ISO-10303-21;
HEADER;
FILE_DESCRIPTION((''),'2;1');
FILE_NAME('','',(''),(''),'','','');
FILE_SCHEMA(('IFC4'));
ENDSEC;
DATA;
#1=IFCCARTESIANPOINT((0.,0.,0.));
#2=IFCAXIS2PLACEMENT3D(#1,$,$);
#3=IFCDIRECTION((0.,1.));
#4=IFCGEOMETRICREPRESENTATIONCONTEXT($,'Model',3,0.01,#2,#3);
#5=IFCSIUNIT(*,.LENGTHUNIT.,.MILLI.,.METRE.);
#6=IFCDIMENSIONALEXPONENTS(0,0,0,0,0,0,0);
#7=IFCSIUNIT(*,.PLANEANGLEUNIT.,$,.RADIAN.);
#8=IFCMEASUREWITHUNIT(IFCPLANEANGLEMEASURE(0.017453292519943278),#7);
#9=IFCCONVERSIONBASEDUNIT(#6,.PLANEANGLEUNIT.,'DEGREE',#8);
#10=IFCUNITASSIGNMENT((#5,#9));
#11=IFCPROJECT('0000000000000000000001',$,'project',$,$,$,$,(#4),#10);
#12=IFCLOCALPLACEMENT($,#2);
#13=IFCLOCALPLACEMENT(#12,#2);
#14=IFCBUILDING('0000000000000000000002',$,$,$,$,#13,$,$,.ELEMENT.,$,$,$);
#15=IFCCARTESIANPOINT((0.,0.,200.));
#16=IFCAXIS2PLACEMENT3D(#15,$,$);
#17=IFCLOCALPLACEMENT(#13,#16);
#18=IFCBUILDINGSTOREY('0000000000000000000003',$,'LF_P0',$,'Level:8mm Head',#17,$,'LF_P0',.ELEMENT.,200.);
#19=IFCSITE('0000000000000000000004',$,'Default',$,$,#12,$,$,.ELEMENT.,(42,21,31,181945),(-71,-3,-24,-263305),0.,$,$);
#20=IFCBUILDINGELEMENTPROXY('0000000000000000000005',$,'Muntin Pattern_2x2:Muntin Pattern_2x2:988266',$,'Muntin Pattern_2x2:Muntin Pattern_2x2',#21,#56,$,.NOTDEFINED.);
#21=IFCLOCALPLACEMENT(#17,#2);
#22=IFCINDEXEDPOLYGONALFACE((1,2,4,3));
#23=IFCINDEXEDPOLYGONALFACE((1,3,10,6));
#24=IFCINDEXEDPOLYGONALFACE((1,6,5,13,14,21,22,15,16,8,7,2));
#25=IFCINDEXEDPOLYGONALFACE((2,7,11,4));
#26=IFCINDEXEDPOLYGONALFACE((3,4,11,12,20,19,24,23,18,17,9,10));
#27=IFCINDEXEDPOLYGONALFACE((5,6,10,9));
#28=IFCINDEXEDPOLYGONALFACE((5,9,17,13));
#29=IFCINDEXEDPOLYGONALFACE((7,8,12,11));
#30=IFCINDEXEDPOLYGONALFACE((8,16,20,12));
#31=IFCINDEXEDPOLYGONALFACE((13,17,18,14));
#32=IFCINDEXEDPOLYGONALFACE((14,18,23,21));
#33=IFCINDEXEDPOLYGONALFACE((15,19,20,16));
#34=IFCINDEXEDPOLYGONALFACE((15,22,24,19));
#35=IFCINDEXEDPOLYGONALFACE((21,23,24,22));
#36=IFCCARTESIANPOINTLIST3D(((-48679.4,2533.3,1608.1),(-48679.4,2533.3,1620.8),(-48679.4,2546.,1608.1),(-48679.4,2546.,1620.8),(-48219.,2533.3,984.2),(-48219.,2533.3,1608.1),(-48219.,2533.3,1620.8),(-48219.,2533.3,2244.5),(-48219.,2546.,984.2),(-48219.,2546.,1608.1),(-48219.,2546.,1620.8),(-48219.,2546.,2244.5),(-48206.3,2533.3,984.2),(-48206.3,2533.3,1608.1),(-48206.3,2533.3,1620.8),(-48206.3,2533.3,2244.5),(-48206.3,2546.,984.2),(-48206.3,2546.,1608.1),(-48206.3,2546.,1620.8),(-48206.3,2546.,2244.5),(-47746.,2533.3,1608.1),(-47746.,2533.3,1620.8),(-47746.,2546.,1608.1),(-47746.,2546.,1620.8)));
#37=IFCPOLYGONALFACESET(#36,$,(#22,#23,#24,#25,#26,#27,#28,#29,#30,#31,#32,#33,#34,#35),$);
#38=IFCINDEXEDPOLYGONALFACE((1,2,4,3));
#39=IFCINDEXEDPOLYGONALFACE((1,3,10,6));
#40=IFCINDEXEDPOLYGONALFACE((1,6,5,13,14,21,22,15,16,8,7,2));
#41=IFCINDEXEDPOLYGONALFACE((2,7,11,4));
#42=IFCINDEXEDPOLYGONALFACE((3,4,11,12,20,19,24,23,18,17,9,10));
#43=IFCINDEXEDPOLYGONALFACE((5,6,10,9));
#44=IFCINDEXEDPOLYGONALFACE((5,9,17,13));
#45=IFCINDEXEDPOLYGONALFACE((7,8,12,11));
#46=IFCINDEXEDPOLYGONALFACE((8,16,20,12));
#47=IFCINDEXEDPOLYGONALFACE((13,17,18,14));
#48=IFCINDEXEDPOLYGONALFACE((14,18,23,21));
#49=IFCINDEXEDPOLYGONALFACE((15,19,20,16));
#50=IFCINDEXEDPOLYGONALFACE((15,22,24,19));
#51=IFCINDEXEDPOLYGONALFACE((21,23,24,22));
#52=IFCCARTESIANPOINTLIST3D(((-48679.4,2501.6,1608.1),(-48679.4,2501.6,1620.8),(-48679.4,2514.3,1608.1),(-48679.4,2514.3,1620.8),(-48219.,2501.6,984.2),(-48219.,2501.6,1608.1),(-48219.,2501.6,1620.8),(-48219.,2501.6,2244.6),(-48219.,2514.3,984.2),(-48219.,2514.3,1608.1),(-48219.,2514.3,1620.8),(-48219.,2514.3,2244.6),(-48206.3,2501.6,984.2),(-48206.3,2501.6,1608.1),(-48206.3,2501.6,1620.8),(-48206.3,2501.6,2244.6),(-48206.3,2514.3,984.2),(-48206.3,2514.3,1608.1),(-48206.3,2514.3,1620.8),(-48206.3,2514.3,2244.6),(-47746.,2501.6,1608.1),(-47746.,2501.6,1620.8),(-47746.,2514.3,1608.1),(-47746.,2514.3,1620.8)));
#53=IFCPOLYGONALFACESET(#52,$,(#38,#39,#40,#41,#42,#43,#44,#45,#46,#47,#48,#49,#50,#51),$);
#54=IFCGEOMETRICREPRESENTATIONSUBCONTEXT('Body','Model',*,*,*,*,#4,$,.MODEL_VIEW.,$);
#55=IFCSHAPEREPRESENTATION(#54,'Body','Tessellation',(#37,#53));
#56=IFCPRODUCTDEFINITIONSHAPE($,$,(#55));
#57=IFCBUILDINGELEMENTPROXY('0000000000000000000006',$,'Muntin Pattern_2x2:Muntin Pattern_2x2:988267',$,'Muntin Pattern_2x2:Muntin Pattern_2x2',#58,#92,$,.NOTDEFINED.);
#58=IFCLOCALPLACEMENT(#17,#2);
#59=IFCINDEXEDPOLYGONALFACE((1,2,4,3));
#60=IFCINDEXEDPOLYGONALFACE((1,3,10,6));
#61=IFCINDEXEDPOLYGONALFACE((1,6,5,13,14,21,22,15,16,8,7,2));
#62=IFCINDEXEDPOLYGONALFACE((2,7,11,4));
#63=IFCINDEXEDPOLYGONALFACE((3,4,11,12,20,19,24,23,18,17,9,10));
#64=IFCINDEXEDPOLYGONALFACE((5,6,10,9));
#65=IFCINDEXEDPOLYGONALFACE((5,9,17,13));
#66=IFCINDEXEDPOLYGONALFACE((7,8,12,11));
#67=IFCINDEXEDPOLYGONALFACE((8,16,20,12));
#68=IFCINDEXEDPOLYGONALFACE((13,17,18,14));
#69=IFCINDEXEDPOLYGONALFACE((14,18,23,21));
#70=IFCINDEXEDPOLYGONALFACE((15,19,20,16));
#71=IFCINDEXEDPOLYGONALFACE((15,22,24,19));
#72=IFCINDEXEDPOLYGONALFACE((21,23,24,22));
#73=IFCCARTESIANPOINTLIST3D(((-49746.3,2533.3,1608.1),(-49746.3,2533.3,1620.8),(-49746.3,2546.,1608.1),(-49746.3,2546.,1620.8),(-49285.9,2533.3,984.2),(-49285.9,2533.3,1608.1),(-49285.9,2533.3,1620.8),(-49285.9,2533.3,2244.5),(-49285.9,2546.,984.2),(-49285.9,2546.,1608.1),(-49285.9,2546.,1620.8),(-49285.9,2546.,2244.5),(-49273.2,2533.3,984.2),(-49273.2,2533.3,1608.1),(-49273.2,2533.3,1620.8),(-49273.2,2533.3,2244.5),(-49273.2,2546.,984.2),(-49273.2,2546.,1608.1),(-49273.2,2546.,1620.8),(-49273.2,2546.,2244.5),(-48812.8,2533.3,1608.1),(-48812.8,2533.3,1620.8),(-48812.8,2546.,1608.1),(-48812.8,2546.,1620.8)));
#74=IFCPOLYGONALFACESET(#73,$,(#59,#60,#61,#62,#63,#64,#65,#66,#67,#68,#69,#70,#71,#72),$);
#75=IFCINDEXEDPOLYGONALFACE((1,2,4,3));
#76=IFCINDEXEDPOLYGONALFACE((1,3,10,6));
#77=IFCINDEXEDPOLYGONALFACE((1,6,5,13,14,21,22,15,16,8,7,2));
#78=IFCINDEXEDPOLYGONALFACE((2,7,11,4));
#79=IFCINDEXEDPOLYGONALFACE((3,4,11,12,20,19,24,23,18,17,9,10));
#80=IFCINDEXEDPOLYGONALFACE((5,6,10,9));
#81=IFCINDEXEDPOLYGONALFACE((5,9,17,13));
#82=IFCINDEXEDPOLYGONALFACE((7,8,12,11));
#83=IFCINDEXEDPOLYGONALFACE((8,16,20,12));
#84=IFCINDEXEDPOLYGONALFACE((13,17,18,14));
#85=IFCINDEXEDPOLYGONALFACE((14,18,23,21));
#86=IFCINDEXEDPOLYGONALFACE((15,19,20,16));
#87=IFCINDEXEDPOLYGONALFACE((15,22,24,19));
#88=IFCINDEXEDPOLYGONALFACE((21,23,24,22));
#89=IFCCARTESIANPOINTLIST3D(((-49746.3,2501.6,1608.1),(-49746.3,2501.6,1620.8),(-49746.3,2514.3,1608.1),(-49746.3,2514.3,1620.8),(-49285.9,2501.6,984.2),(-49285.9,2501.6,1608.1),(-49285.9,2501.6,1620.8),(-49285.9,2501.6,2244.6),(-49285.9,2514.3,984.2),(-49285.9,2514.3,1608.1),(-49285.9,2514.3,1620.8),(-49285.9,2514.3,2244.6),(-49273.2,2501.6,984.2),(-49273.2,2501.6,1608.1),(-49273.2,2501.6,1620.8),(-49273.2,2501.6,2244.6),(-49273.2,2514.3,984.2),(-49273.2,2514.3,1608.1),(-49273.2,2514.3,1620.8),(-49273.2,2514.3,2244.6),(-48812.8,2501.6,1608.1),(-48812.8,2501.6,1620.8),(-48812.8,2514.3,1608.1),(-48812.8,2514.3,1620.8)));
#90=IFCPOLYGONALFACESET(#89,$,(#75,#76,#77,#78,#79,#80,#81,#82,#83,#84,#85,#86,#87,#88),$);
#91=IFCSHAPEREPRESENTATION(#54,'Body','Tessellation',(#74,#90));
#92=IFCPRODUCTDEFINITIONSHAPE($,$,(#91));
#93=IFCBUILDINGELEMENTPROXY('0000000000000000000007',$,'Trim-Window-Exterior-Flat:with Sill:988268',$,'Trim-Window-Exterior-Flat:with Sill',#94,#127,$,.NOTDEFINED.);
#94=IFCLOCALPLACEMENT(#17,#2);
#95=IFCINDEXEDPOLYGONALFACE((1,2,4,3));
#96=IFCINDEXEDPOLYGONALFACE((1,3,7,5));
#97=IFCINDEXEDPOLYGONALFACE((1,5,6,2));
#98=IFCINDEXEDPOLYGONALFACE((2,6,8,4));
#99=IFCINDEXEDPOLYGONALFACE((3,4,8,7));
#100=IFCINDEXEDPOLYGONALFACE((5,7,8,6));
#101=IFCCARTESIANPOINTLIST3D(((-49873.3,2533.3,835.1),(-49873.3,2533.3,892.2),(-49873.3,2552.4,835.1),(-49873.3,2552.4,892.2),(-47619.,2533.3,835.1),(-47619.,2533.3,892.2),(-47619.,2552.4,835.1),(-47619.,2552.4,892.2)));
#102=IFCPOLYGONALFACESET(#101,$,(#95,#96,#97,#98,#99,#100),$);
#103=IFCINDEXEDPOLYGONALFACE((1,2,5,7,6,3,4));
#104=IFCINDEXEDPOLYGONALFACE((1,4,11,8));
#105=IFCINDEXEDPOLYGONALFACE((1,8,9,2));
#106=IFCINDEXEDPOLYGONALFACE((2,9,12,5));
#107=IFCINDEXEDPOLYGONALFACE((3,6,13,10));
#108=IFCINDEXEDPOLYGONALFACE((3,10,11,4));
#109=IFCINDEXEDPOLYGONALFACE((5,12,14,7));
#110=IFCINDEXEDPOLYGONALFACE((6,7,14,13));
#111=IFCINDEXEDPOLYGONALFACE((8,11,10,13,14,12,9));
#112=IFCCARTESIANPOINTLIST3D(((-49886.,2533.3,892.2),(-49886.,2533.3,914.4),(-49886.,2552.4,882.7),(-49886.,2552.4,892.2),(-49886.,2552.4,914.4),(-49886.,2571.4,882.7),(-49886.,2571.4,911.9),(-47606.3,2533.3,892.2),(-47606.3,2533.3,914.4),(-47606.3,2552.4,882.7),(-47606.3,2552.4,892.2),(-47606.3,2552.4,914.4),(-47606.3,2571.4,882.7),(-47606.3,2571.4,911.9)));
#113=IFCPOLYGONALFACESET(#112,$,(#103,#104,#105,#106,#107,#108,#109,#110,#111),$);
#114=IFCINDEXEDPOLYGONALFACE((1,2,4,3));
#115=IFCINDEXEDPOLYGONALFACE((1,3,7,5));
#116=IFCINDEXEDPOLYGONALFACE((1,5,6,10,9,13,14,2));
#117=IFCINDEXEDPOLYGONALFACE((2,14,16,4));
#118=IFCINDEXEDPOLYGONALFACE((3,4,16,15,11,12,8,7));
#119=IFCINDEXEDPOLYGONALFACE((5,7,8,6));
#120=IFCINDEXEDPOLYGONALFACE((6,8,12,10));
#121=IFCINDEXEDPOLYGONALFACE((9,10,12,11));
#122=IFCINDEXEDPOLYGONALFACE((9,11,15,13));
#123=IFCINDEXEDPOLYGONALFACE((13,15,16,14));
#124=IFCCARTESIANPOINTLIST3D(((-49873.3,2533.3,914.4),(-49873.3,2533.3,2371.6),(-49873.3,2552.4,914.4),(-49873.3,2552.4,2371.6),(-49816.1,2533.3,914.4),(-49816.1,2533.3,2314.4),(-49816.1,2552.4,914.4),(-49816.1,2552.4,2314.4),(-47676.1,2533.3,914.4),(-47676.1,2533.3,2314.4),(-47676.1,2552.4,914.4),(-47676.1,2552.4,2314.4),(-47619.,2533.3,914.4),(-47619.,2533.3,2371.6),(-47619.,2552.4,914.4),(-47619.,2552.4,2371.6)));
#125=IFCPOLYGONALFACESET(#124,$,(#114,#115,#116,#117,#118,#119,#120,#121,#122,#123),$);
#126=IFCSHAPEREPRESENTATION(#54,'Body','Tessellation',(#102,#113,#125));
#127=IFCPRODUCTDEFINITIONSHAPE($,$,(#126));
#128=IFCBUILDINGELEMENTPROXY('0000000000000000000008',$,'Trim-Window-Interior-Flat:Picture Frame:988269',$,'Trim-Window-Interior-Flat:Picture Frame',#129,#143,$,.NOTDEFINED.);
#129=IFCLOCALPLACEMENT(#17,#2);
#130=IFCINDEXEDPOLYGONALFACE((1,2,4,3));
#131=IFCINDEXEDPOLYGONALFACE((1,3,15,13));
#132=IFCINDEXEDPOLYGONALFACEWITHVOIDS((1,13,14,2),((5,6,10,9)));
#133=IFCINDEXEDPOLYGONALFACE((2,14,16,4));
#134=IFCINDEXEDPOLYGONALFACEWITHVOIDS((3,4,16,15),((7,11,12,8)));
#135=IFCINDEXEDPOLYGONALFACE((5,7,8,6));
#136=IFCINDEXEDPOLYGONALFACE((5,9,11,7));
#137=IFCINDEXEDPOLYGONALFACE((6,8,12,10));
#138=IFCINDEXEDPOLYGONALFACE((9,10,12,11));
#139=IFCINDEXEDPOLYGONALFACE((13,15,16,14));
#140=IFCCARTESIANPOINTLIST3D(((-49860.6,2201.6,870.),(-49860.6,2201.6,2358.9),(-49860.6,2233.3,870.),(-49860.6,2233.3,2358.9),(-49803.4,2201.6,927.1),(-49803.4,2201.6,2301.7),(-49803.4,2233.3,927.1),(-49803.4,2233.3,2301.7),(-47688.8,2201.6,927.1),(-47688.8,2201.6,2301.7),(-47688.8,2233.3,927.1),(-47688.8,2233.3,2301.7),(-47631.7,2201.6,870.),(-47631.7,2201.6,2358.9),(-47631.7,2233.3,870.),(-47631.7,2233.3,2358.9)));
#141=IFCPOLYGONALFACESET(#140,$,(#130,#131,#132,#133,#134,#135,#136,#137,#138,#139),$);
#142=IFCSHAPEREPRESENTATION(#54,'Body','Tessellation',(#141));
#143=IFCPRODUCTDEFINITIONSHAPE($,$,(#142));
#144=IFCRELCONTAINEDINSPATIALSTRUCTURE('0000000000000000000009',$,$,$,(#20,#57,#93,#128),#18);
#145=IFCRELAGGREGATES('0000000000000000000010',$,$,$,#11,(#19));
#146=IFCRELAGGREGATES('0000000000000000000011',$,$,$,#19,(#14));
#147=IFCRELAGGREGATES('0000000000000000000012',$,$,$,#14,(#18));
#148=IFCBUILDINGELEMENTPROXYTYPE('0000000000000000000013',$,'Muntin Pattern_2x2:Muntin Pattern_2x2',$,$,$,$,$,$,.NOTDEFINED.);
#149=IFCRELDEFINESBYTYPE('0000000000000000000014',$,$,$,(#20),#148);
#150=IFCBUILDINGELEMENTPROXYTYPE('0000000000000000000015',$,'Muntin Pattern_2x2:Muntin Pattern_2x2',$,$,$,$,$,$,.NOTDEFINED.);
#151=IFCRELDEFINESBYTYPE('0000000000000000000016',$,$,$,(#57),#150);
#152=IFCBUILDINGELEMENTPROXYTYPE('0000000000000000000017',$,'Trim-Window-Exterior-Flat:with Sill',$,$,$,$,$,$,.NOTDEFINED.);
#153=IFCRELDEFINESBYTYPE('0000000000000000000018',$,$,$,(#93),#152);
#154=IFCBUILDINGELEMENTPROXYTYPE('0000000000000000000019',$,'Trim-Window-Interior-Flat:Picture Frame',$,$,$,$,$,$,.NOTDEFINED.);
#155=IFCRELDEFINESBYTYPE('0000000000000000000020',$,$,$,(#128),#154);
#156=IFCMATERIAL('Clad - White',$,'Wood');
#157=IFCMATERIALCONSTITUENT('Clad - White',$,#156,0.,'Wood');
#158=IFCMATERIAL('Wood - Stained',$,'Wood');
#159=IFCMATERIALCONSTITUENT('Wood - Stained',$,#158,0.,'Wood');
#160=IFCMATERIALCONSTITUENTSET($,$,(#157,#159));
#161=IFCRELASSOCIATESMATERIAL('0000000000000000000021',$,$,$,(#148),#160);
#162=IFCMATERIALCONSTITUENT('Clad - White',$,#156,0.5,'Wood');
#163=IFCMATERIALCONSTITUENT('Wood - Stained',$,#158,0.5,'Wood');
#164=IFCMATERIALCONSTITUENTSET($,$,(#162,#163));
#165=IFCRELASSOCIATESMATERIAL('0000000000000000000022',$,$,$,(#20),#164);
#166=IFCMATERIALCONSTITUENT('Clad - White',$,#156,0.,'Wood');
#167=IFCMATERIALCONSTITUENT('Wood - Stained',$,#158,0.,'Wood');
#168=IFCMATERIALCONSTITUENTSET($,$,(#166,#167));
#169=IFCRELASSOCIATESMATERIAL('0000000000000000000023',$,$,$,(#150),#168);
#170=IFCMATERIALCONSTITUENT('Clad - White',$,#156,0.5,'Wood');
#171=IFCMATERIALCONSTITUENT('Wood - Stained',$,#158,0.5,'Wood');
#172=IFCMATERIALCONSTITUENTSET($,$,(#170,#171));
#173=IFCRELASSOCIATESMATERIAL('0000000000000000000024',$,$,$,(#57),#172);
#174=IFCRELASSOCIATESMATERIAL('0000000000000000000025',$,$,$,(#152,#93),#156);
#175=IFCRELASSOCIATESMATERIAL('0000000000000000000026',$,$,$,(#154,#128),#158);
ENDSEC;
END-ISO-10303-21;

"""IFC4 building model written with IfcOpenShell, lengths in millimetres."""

from ifc_helpers import new_model, entity, si_unit, converted_unit, direction, frame, origin, place, context, subcontext, project, spatial, indexed_curve, outline, extrude, source, transform, mapped, material, constituent, constituent_set, type_object, type_shapes, element, save


model = new_model("IFC4")

# Units and contexts
model_context = context("Model", 3, precision=0.01, world=origin(), true_north=direction((0.0, 1.0)))
body_context = subcontext(model_context, "Body", "Model", "MODEL_VIEW")
ifc_project = project(units=[si_unit("LENGTHUNIT", "METRE", prefix="MILLI"), converted_unit("PLANEANGLEUNIT", "DEGREE", entity("IfcPlaneAngleMeasure", 0.017453292519943278), si_unit("PLANEANGLEUNIT", "RADIAN"), dimensions=[0, 0, 0, 0, 0, 0, 0])], contexts=[model_context])

# Site, building, storey
site_placement = place(None, origin())
site = spatial("IfcSite", under=ifc_project, at=site_placement, Name="Default", CompositionType="ELEMENT", RefLatitude=(42, 21, 31, 181945), RefLongitude=(-71, -3, -24, -263305), RefElevation=0.0)
building_placement = place(site_placement, origin())
building = spatial("IfcBuilding", under=site, at=building_placement, CompositionType="ELEMENT")
storey_placement = place(building_placement, frame((0.0, 0.0, 200.0)))
storey = spatial("IfcBuildingStorey", under=building, at=storey_placement, Name="LF_P0", ObjectType="Level:8mm Head", LongName="LF_P0", CompositionType="ELEMENT", Elevation=200.0)

# Building element proxies
ifc_material_1 = material(Name="Clad - White", Category="Wood")
ifc_constituent_1 = constituent(ifc_material_1, Name="Clad - White", Category="Wood", fraction=0.5)
ifc_material_2 = material(Name="Wood - Stained", Category="Wood")
ifc_constituent_2 = constituent(ifc_material_2, Name="Wood - Stained", Category="Wood", fraction=0.5)
ifc_constituent_set_1 = constituent_set(constituents=[ifc_constituent_1, ifc_constituent_2])
ifc_constituent_3 = constituent(ifc_material_1, Name="Clad - White", Category="Wood", fraction=0.0)
ifc_constituent_4 = constituent(ifc_material_2, Name="Wood - Stained", Category="Wood", fraction=0.0)
ifc_constituent_set_2 = constituent_set(constituents=[ifc_constituent_3, ifc_constituent_4])
building_element_proxy_type_1 = type_object("IfcBuildingElementProxyType", Name="Muntin Pattern_2x2:Muntin Pattern_2x2", PredefinedType="NOTDEFINED", material=ifc_constituent_set_2)
shared_shape_1 = source(origin(), body_context, "Body", "SweptSolid", [
    extrude(outline(indexed_curve([(6.4, -6.4), (630.1, -6.4), (630.1, 6.3), (6.4, 6.3), (6.4, 466.7), (-6.3, 466.7), (-6.3, 6.3), (-630.2, 6.3), (-630.2, -6.4), (-6.3, -6.4), (-6.3, -466.7), (6.4, -466.7), (6.4, -6.4)], self_intersect=False)), frame((0.0, -22.2, 630.1), z_axis=(0.0, 1.0, 0.0), x_axis=(0.0, 0.0, 1.0)), (0.0, 0.0, 1.0), 12.7),
    extrude(outline(indexed_curve([(6.4, -6.4), (630.2, -6.4), (630.2, 6.3), (6.4, 6.3), (6.4, 466.7), (-6.3, 466.7), (-6.3, 6.3), (-630.2, 6.3), (-630.2, -6.4), (-6.3, -6.4), (-6.3, -466.7), (6.4, -466.7), (6.4, -6.4)], self_intersect=False)), frame((0.0, 9.5, 630.2), z_axis=(0.0, 1.0, 0.0), x_axis=(0.0, 0.0, 1.0)), (0.0, 0.0, 1.0), 12.7),
])
type_shapes(building_element_proxy_type_1, [shared_shape_1])
proxy_1_placement = place(storey_placement, frame((-48212.7, 2523.8, 984.3), z_axis=(0.0, 0.0, 1.0), x_axis=(-1.0, 0.0, 0.0)))
element("IfcBuildingElementProxy", 1, at=proxy_1_placement, inside=storey, type_object=building_element_proxy_type_1, material=ifc_constituent_set_1, Name="Muntin Pattern_2x2:Muntin Pattern_2x2:988266", ObjectType="Muntin Pattern_2x2:Muntin Pattern_2x2", PredefinedType="NOTDEFINED", context=body_context, shape_type="MappedRepresentation", body=[
    mapped(shared_shape_1, transform((0.0, 0.0, 0.0), scale=1.0)),
])
ifc_constituent_5 = constituent(ifc_material_1, Name="Clad - White", Category="Wood", fraction=0.5)
ifc_constituent_6 = constituent(ifc_material_2, Name="Wood - Stained", Category="Wood", fraction=0.5)
ifc_constituent_set_3 = constituent_set(constituents=[ifc_constituent_5, ifc_constituent_6])
ifc_constituent_7 = constituent(ifc_material_1, Name="Clad - White", Category="Wood", fraction=0.0)
ifc_constituent_8 = constituent(ifc_material_2, Name="Wood - Stained", Category="Wood", fraction=0.0)
ifc_constituent_set_4 = constituent_set(constituents=[ifc_constituent_7, ifc_constituent_8])
building_element_proxy_type_2 = type_object("IfcBuildingElementProxyType", Name="Muntin Pattern_2x2:Muntin Pattern_2x2", PredefinedType="NOTDEFINED", material=ifc_constituent_set_4)
shared_shape_2 = source(origin(), body_context, "Body", "SweptSolid", [
    extrude(outline(indexed_curve([(6.4, -6.4), (630.1, -6.4), (630.1, 6.3), (6.4, 6.3), (6.4, 466.7), (-6.3, 466.7), (-6.3, 6.3), (-630.2, 6.3), (-630.2, -6.4), (-6.3, -6.4), (-6.3, -466.7), (6.4, -466.7), (6.4, -6.4)], self_intersect=False)), frame((0.0, 9.5, 630.1), z_axis=(0.0, 1.0, 0.0), x_axis=(0.0, 0.0, 1.0)), (0.0, 0.0, 1.0), 12.7),
    extrude(outline(indexed_curve([(6.4, -6.4), (630.2, -6.4), (630.2, 6.3), (6.4, 6.3), (6.4, 466.7), (-6.3, 466.7), (-6.3, 6.3), (-630.2, 6.3), (-630.2, -6.4), (-6.3, -6.4), (-6.3, -466.7), (6.4, -466.7), (6.4, -6.4)], self_intersect=False)), frame((0.0, -22.2, 630.2), z_axis=(0.0, 1.0, 0.0), x_axis=(0.0, 0.0, 1.0)), (0.0, 0.0, 1.0), 12.7),
])
type_shapes(building_element_proxy_type_2, [shared_shape_2])
proxy_2_placement = place(storey_placement, frame((-49279.5, 2523.8, 984.3)))
element("IfcBuildingElementProxy", 2, at=proxy_2_placement, inside=storey, type_object=building_element_proxy_type_2, material=ifc_constituent_set_3, Name="Muntin Pattern_2x2:Muntin Pattern_2x2:988267", ObjectType="Muntin Pattern_2x2:Muntin Pattern_2x2", PredefinedType="NOTDEFINED", context=body_context, shape_type="MappedRepresentation", body=[
    mapped(shared_shape_2, transform((0.0, 0.0, 0.0), scale=1.0)),
])
building_element_proxy_type_3 = type_object("IfcBuildingElementProxyType", Name="Trim-Window-Exterior-Flat:with Sill", PredefinedType="NOTDEFINED", material=ifc_material_1)
shared_shape_3 = source(origin(), body_context, "Body", "SweptSolid", [
    extrude(outline(indexed_curve([(-28.6, -1127.1), (28.6, -1127.1), (28.6, 1127.1), (-28.6, 1127.1), (-28.6, -1127.1)], self_intersect=False)), frame((0.0, 1450.8, 0.0), z_axis=(0.0, 0.0, 1.0), x_axis=(0.0, 1.0, 0.0)), (0.0, 0.0, 1.0), 19.0),
    extrude(outline(indexed_curve([(-16.0, -19.0), (13.3, -19.0), (15.8, 0.0), (15.8, 19.0), (-6.4, 19.0), (-6.4, 0.0), (-16.0, 0.0), (-16.0, -19.0)], self_intersect=False)), frame((-1139.8, 1415.8, 19.0), z_axis=(1.0, 0.0, 0.0), x_axis=(0.0, -1.0, 0.0)), (0.0, 0.0, 1.0), 2279.7),
    extrude(outline(indexed_curve([(-1127.1, -742.9), (1127.1, -742.9), (1127.1, 714.3), (1070.0, 714.3), (1070.0, -685.7), (-1070.0, -685.7), (-1070.0, 714.3), (-1127.1, 714.3), (-1127.1, -742.9)], self_intersect=False)), frame((0.0, 685.7, 0.0)), (0.0, 0.0, 1.0), 19.0),
])
type_shapes(building_element_proxy_type_3, [shared_shape_3])
proxy_3_placement = place(storey_placement, frame((-48746.1, 2533.3, 2314.4), z_axis=(0.0, 1.0, 0.0), x_axis=(1.0, 0.0, 0.0)))
element("IfcBuildingElementProxy", 3, at=proxy_3_placement, inside=storey, type_object=building_element_proxy_type_3, material=ifc_material_1, Name="Trim-Window-Exterior-Flat:with Sill:988268", ObjectType="Trim-Window-Exterior-Flat:with Sill", PredefinedType="NOTDEFINED", context=body_context, shape_type="MappedRepresentation", body=[
    mapped(shared_shape_3, transform((0.0, 0.0, 0.0), scale=1.0)),
])
building_element_proxy_type_4 = type_object("IfcBuildingElementProxyType", Name="Trim-Window-Interior-Flat:Picture Frame", PredefinedType="NOTDEFINED", material=ifc_material_2)
shared_shape_4 = source(origin(), body_context, "Body", "SweptSolid", [
    extrude(outline(indexed_curve([(-744.4, -1114.4), (744.4, -1114.4), (744.4, 1114.4), (-744.4, 1114.4), (-744.4, -1114.4)], self_intersect=False), holes=[indexed_curve([(-687.3, -1057.3), (-687.3, 1057.3), (687.3, 1057.3), (687.3, -1057.3), (-687.3, -1057.3)], self_intersect=False)]), frame((0.0, 700.0, 0.0), z_axis=(0.0, 0.0, 1.0), x_axis=(0.0, 1.0, 0.0)), (0.0, 0.0, 1.0), 31.7),
])
type_shapes(building_element_proxy_type_4, [shared_shape_4])
proxy_4_placement = place(storey_placement, frame((-48746.1, 2233.3, 2314.4), z_axis=(0.0, -1.0, 0.0), x_axis=(-1.0, 0.0, 0.0)))
element("IfcBuildingElementProxy", 4, at=proxy_4_placement, inside=storey, type_object=building_element_proxy_type_4, material=ifc_material_2, Name="Trim-Window-Interior-Flat:Picture Frame:988269", ObjectType="Trim-Window-Interior-Flat:Picture Frame", PredefinedType="NOTDEFINED", context=body_context, shape_type="MappedRepresentation", body=[
    mapped(shared_shape_4, transform((0.0, 0.0, 0.0), scale=1.0)),
])

save(model, "model.ifc")
